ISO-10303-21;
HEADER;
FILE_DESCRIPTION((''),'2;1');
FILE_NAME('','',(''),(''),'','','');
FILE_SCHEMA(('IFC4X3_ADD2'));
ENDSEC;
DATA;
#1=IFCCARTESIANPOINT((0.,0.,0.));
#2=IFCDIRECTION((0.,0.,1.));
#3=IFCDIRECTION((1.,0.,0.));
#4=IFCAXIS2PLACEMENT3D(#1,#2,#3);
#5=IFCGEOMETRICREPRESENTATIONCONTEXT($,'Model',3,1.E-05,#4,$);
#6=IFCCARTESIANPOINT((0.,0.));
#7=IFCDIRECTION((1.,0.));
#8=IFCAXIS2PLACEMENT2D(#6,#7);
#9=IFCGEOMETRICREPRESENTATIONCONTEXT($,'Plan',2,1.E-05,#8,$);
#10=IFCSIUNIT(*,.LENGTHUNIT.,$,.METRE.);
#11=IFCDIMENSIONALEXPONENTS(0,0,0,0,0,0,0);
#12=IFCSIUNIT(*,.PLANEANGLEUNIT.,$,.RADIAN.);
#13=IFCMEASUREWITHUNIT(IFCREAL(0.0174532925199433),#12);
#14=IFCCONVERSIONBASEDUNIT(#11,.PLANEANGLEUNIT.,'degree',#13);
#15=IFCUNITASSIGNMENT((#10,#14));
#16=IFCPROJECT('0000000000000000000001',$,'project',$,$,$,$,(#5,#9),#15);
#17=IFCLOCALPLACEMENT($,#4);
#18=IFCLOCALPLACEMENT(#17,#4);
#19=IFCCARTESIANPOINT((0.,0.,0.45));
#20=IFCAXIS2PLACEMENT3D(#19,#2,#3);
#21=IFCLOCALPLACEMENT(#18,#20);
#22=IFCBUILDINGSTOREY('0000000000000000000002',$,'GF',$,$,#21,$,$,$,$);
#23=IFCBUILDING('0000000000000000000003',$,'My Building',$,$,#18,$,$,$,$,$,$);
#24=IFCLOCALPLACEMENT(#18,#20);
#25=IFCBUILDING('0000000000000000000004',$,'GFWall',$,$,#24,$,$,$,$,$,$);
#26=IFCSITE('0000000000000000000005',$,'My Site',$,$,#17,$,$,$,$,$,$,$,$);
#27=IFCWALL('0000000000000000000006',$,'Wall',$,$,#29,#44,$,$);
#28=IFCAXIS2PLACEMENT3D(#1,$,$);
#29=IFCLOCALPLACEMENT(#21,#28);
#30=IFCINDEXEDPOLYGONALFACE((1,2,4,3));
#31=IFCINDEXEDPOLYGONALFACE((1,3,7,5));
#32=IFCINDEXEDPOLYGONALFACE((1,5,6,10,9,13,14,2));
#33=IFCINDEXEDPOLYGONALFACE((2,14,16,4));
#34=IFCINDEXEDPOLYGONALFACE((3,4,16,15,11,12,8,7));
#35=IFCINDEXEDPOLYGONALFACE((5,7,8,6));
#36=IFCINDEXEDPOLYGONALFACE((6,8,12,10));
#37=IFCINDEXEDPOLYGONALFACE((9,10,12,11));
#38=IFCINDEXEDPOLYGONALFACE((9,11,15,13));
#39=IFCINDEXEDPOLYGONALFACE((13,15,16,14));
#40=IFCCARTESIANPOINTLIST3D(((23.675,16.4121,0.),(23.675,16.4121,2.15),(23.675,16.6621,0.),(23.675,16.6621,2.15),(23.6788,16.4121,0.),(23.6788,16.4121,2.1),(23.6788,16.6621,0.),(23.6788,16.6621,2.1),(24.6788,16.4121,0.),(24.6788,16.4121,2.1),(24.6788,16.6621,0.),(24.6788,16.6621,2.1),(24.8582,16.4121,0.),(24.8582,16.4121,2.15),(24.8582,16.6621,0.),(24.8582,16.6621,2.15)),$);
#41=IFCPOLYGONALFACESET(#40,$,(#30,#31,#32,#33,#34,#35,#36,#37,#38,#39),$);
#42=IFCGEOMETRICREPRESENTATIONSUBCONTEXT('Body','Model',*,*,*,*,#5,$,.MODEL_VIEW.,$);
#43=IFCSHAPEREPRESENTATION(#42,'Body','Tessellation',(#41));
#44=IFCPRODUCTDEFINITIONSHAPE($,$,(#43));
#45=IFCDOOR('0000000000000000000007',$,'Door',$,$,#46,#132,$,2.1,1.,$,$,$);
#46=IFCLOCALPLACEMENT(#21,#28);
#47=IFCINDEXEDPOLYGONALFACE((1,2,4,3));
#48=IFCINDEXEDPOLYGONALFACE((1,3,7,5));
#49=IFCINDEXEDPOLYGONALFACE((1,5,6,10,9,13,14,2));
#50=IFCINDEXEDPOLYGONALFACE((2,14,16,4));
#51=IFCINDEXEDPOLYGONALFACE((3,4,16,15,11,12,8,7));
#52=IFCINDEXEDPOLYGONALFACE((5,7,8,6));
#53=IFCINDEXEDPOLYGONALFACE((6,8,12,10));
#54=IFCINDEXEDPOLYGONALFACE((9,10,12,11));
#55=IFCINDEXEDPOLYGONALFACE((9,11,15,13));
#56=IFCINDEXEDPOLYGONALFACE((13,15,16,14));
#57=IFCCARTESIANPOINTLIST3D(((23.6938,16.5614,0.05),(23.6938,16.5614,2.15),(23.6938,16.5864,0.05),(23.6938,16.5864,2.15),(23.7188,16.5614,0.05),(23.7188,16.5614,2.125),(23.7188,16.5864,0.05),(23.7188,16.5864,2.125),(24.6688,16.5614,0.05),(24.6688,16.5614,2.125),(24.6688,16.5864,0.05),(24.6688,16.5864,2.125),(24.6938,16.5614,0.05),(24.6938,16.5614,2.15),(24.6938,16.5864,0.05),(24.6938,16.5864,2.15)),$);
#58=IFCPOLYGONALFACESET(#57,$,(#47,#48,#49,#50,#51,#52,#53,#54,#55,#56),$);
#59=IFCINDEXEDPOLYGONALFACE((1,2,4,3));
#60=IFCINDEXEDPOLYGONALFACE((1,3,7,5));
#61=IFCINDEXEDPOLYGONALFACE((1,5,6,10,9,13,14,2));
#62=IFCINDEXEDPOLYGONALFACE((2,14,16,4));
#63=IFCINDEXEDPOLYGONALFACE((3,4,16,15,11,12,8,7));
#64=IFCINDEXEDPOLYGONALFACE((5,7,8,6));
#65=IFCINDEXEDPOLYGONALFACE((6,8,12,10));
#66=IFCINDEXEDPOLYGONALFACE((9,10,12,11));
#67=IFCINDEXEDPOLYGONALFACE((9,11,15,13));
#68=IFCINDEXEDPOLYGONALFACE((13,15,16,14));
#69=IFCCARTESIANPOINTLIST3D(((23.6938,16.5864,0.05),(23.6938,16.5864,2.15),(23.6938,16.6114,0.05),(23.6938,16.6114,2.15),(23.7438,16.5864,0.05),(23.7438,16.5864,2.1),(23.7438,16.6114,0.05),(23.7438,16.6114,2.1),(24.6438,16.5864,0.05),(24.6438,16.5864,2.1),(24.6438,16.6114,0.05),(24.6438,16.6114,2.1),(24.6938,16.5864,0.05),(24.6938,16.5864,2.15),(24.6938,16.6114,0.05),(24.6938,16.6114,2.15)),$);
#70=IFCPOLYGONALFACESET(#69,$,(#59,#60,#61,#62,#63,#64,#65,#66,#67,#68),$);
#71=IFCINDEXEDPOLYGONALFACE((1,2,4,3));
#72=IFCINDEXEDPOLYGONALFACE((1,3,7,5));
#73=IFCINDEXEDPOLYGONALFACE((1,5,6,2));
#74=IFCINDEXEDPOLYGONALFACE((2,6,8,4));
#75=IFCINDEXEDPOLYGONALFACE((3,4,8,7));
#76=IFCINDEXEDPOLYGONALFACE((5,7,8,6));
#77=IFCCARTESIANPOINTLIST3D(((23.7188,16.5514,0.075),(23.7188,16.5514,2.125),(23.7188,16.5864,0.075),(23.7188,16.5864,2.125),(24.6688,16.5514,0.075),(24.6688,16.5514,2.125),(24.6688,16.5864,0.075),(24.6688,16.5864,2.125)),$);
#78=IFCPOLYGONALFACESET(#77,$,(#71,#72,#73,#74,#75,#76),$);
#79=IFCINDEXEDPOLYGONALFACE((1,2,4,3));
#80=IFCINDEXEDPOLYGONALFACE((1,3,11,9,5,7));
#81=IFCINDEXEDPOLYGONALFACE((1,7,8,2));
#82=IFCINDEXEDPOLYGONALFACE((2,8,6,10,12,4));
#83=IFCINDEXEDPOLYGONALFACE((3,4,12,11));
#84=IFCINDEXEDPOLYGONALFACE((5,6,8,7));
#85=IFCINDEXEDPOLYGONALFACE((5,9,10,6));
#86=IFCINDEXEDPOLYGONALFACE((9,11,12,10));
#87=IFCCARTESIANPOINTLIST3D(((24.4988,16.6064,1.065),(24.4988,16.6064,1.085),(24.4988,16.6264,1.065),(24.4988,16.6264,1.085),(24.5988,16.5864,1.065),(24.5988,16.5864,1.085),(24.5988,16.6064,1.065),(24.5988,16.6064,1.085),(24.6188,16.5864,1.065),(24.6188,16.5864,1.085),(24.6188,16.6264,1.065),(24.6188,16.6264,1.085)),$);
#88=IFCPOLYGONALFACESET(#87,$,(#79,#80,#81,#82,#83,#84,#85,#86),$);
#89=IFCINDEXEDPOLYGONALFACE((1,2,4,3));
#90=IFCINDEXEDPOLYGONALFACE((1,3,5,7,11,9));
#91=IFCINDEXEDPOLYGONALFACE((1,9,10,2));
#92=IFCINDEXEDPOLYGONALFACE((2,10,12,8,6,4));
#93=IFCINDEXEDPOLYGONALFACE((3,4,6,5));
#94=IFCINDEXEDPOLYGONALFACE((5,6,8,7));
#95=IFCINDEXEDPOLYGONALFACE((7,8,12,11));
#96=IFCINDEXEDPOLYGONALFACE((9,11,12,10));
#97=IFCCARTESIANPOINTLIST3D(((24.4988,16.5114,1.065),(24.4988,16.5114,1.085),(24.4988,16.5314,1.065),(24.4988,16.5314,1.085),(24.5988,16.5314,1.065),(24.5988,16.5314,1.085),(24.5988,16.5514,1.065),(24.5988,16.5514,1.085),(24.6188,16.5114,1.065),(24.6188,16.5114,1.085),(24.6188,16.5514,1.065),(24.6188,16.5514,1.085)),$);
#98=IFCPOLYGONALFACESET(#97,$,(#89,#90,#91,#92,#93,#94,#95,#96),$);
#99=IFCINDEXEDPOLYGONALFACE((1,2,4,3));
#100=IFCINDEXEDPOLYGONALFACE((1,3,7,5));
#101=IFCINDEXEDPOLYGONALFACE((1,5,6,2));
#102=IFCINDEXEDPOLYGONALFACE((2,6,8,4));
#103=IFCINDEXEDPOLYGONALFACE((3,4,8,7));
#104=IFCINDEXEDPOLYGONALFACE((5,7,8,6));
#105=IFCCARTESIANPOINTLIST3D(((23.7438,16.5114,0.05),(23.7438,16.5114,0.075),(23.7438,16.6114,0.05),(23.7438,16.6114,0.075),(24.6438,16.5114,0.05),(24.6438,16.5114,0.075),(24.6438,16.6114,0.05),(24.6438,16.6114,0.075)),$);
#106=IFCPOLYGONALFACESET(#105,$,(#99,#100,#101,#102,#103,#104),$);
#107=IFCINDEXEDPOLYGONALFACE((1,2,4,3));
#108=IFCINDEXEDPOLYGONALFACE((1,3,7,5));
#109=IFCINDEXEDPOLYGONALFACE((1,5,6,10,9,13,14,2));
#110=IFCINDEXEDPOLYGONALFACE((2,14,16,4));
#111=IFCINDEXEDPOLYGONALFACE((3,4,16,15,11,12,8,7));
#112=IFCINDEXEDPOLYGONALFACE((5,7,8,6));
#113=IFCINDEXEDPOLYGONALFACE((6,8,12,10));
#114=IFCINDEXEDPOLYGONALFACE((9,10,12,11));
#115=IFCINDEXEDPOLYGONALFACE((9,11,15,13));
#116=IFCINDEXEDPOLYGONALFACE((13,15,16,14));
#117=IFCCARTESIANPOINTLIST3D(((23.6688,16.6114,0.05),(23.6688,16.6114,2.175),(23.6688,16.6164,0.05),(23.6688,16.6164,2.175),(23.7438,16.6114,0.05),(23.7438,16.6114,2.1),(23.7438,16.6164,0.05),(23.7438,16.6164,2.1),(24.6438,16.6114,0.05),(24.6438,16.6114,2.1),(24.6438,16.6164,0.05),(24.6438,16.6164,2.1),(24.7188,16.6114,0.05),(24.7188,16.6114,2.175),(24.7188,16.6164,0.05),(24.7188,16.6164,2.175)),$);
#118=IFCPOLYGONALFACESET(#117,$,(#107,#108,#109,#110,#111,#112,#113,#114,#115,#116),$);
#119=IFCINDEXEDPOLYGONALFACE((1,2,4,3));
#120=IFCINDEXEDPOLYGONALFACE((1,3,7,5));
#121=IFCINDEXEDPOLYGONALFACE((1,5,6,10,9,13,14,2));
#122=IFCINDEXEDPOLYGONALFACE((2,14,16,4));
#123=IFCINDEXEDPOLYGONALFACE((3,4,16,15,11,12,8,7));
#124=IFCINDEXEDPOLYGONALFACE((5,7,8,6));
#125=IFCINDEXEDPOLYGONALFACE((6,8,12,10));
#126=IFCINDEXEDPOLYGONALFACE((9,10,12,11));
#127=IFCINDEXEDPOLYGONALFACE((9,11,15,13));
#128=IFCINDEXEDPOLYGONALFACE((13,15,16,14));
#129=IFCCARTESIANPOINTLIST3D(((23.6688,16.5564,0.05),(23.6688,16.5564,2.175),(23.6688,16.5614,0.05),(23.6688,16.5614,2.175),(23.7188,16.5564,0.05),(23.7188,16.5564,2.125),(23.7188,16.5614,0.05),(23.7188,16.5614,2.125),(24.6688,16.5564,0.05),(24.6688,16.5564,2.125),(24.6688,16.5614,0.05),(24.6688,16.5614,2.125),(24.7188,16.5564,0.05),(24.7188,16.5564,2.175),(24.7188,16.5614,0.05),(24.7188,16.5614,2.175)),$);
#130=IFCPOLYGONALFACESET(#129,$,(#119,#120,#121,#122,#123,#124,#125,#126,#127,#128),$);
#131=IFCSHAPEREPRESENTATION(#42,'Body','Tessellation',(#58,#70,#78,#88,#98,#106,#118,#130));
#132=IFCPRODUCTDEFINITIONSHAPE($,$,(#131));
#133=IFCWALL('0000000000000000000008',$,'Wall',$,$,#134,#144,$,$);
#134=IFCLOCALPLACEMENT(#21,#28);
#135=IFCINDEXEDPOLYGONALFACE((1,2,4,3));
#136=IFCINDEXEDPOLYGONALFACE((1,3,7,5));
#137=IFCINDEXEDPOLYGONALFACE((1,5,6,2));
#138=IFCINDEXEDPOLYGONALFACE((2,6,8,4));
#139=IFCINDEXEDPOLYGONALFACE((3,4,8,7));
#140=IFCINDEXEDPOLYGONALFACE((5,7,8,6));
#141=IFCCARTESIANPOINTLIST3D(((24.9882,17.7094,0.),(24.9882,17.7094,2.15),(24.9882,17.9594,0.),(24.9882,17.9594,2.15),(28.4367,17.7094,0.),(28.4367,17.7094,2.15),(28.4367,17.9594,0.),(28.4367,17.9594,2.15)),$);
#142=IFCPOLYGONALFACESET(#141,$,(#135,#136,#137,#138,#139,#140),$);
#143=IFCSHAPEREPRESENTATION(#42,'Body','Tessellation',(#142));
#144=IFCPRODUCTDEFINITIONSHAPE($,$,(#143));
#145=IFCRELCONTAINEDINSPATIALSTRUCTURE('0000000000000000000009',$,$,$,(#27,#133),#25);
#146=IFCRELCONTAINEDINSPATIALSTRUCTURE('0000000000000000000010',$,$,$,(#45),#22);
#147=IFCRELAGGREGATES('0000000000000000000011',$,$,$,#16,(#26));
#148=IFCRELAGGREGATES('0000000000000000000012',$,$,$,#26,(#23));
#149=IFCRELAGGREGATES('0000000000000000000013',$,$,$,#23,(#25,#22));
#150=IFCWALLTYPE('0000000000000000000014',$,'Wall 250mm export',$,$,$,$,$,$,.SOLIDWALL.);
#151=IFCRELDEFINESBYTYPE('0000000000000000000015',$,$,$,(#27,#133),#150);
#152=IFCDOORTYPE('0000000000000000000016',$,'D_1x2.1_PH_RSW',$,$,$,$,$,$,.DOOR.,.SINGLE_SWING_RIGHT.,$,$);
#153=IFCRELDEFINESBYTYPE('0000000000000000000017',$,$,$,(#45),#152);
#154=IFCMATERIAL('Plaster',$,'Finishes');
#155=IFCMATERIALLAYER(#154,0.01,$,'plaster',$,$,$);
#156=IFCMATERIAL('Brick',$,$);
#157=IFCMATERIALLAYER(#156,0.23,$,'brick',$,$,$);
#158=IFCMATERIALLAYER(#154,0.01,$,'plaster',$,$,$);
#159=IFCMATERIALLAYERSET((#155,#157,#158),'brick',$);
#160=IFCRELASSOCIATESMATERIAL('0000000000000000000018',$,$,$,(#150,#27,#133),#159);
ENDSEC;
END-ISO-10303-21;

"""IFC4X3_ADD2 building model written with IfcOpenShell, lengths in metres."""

from ifc_helpers import new_model, entity, si_unit, converted_unit, frame, origin_with_axes, origin_2d_with_axis, place, context, subcontext, project, spatial, line, indexed_curve, outline, extrude, shape, source, transform, mapped, material, layer, layer_set, layer_usage, type_object, type_shapes, element, fill, save


model = new_model("IFC4X3_ADD2")

# Units and contexts
model_context = context("Model", 3, precision=1e-05, world=origin_with_axes())
plan_context = context("Plan", 2, precision=1e-05, world=origin_2d_with_axis())
body_context_1 = subcontext(model_context, "Body", "Model", "MODEL_VIEW")
body_context_2 = subcontext(plan_context, "Body", "Plan", "PLAN_VIEW")
ifc_project = project(units=[si_unit("LENGTHUNIT", "METRE"), converted_unit("PLANEANGLEUNIT", "degree", entity("IfcReal", 0.0174532925199433), si_unit("PLANEANGLEUNIT", "RADIAN"), dimensions=[0, 0, 0, 0, 0, 0, 0])], contexts=[model_context, plan_context])

# Site, buildings
site_placement = place(None, origin_with_axes())
site = spatial("IfcSite", under=ifc_project, at=site_placement, Name="My Site")
building_1_placement = place(site_placement, origin_with_axes())
building_1 = spatial("IfcBuilding", under=site, at=building_1_placement, Name="My Building")
building_2_placement = place(building_1_placement, frame((0.0, 0.0, 0.45), z_axis=(0.0, 0.0, 1.0), x_axis=(1.0, 0.0, 0.0)))
building_2 = spatial("IfcBuilding", under=building_1, at=building_2_placement, Name="GFWall")

# Shared definitions
storey_placement = place(building_1_placement, frame((0.0, 0.0, 0.45), z_axis=(0.0, 0.0, 1.0), x_axis=(1.0, 0.0, 0.0)))
storey = spatial("IfcBuildingStorey", under=building_1, at=storey_placement, Name="GF")

# Shared definitions
ifc_material_1 = material(Name="Plaster", Category="Finishes")

# Shared definitions
ifc_layer_1 = layer(ifc_material_1, 0.01, Name="plaster")
ifc_material_2 = material(Name="Brick")
ifc_layer_2 = layer(ifc_material_2, 0.23, Name="brick")
ifc_layer_3 = layer(ifc_material_1, 0.01, Name="plaster")
ifc_layer_set_1 = layer_set([ifc_layer_1, ifc_layer_2, ifc_layer_3], Name="brick")
wall_type_1 = type_object("IfcWallType", Name="Wall 250mm export", PredefinedType="SOLIDWALL", material=ifc_layer_set_1)

# Wall, opening, door
ifc_layer_usage_1 = layer_usage(ifc_layer_set_1, "AXIS2", "POSITIVE", 0.0)
wall_1_placement = place(building_2_placement, frame((23.675, 16.4121, 0.0), z_axis=(0.0, 0.0, 1.0), x_axis=(1.0, 0.0, 0.0)))
wall_1 = element("IfcWall", 1, at=wall_1_placement, inside=building_2, type_object=wall_type_1, material=ifc_layer_usage_1, Name="Wall", context=body_context_1, shape_type="SweptSolid", body=[
    extrude(outline(indexed_curve([(0.0, 0.0), (0.0, 0.25), (1.1832, 0.25), (1.1832, 0.0)], segments=[line(1, 2, 3, 4, 1)])), origin_with_axes(), (0.0, 0.0, 1.0), 2.15),
])
shared_shape_1 = source(origin_with_axes(), body_context_1, "Body", "SweptSolid", [
    extrude(outline(indexed_curve([(0.0, 0.0), (1.0, 0.0), (1.0, 2.1), (0.0, 2.1)], segments=[line(1, 2, 3, 4, 1)])), frame((0.0, -0.6, 0.0), z_axis=(0.0, -1.0, 0.0), x_axis=(1.0, 0.0, 0.0)), (0.0, 0.0, -1.0), 1.2),
])
opening_1_placement = place(wall_1_placement, frame((1.0037, 0.095, 0.0), z_axis=(0.0, 0.0, 1.0), x_axis=(-1.0, 0.0, 0.0)))
opening_1 = element("IfcOpeningElement", 2, at=opening_1_placement, cuts=wall_1, PredefinedType="OPENING", context=body_context_1, shape_type="MappedRepresentation", body=[
    mapped(shared_shape_1, transform((0.0, 0.0, 0.0), x_axis=(1.0, 0.0, 0.0), y_axis=(0.0, 1.0, 0.0), z_axis=(0.0, 0.0, 1.0), scale=1.0)),
])
door_type_1 = type_object("IfcDoorType", Name="D_1x2.1_PH_RSW", OperationType="SINGLE_SWING_RIGHT", PredefinedType="DOOR")
shared_shape_2 = source(origin_with_axes(), body_context_1, "Body", "SweptSolid", [
    extrude(outline(indexed_curve([(0.0, 0.0), (0.0, 2.1), (1.0, 2.1), (1.0, 0.0), (0.975, 0.0), (0.975, 2.075), (0.025, 2.075), (0.025, 0.0)], segments=[line(1, 2, 3, 4, 5, 6, 7, 8, 1)])), frame((0.0, 0.025, 0.0), z_axis=(0.0, -1.0, 0.0), x_axis=(1.0, 0.0, 0.0)), (0.0, 0.0, -1.0), 0.025),
    extrude(outline(indexed_curve([(0.0, 0.0), (0.0, 2.1), (1.0, 2.1), (1.0, 0.0), (0.95, 0.0), (0.95, 2.05), (0.05, 2.05), (0.05, 0.0)], segments=[line(1, 2, 3, 4, 5, 6, 7, 8, 1)])), frame((0.0, 0.0, 0.0), z_axis=(0.0, -1.0, 0.0), x_axis=(1.0, 0.0, 0.0)), (0.0, 0.0, -1.0), 0.025),
    extrude(outline(indexed_curve([(0.0, 0.0), (0.95, 0.0), (0.95, 0.035), (0.0, 0.035)], segments=[line(1, 2, 3, 4, 1)])), frame((0.025, 0.025, 0.025), z_axis=(0.0, 0.0, 1.0), x_axis=(1.0, 0.0, 0.0)), (0.0, 0.0, 1.0), 2.05),
    extrude(outline(indexed_curve([(0.0, 0.0), (0.0, -0.04), (0.12, -0.04), (0.12, -0.02), (0.02, -0.02), (0.02, 0.0)], segments=[line(1, 2, 3, 4, 5, 6, 1)])), frame((0.075, 0.025, 1.015), z_axis=(0.0, 0.0, 1.0), x_axis=(1.0, 0.0, 0.0)), (0.0, 0.0, 1.0), 0.02),
    extrude(outline(indexed_curve([(0.0, 0.0), (0.0, 0.04), (0.12, 0.04), (0.12, 0.02), (0.02, 0.02), (0.02, 0.0)], segments=[line(1, 2, 3, 4, 5, 6, 1)])), frame((0.075, 0.06, 1.015), z_axis=(0.0, 0.0, 1.0), x_axis=(1.0, 0.0, 0.0)), (0.0, 0.0, 1.0), 0.02),
    extrude(outline(indexed_curve([(0.0, 0.0), (0.9, 0.0), (0.9, 0.1), (0.0, 0.1)], segments=[line(1, 2, 3, 4, 1)])), frame((0.05, 0.0, 0.0), z_axis=(0.0, 0.0, 1.0), x_axis=(1.0, 0.0, 0.0)), (0.0, 0.0, 1.0), 0.025),
    extrude(outline(indexed_curve([(0.0, 0.0), (0.0, 2.125), (1.05, 2.125), (1.05, 0.0), (0.975, 0.0), (0.975, 2.05), (0.075, 2.05), (0.075, 0.0)], segments=[line(1, 2, 3, 4, 5, 6, 7, 8, 1)])), frame((-0.025, -0.005, 0.0), z_axis=(0.0, -1.0, 0.0), x_axis=(1.0, 0.0, 0.0)), (0.0, 0.0, -1.0), 0.005),
    extrude(outline(indexed_curve([(0.0, 0.0), (0.0, 2.125), (1.05, 2.125), (1.05, 0.0), (1.0, 0.0), (1.0, 2.075), (0.05, 2.075), (0.05, 0.0)], segments=[line(1, 2, 3, 4, 5, 6, 7, 8, 1)])), frame((-0.025, 0.05, 0.0), z_axis=(0.0, -1.0, 0.0), x_axis=(1.0, 0.0, 0.0)), (0.0, 0.0, -1.0), 0.005),
])
shared_shape_3 = source(origin_with_axes(), body_context_2, "Body", "Curve2D", [
    entity("IfcIndexedPolyCurve", entity("IfcCartesianPointList2D", [[0.0, 0.0], [0.0, 0.05], [0.025, 0.05], [0.025, 0.025], [0.05, 0.025], [0.05, 0.0]]), [entity("IfcLineIndex", [1, 2, 3, 4, 5, 6, 1])]),
    entity("IfcIndexedPolyCurve", entity("IfcCartesianPointList2D", [[1.0, 0.0], [1.0, 0.05], [0.975, 0.05], [0.975, 0.025], [0.95, 0.025], [0.95, 0.0]]), [entity("IfcLineIndex", [1, 2, 3, 4, 5, 6, 1])]),
    entity("IfcTrimmedCurve", entity("IfcEllipse", entity("IfcAxis2Placement2D", entity("IfcCartesianPoint", [0.94, 0.05]), entity("IfcDirection", [1.0, 0.0])), 0.915, 0.95), [entity("IfcCartesianPoint", [0.94, 1.0])], [entity("IfcCartesianPoint", [0.025, 0.05])], True, "CARTESIAN"),
    entity("IfcIndexedPolyCurve", entity("IfcCartesianPointList2D", [[0.975, 0.05], [0.94, 0.05], [0.94, 1.0], [0.975, 1.0]]), [entity("IfcLineIndex", [1, 2, 3, 4, 1])]),
])
type_shapes(door_type_1, [shared_shape_2, shared_shape_3])
door_1_placement = place(opening_1_placement, frame((-0.015, -0.1044, 0.05), z_axis=(0.0, 0.0, 1.0), x_axis=(1.0, 0.0, 0.0)))
door_1 = element("IfcDoor", 3, at=door_1_placement, inside=storey, type_object=door_type_1, Name="Door", OverallHeight=2.1, OverallWidth=1.0, shapes=[
    shape(body_context_1, "Body", "MappedRepresentation", [mapped(shared_shape_2, transform((0.0, 0.0, 0.0), x_axis=(1.0, 0.0, 0.0), y_axis=(0.0, 1.0, 0.0), z_axis=(0.0, 0.0, 1.0), scale=1.0))]),
    shape(body_context_2, "Body", "MappedRepresentation", [mapped(shared_shape_3, transform((0.0, 0.0, 0.0), x_axis=(1.0, 0.0, 0.0), y_axis=(0.0, 1.0, 0.0), z_axis=(0.0, 0.0, 1.0), scale=1.0))]),
])
fill(opening_1, door_1)

# Wall
ifc_layer_usage_2 = layer_usage(ifc_layer_set_1, "AXIS2", "POSITIVE", 0.0)
wall_2_placement = place(building_2_placement, frame((24.9882, 17.7094, 0.0), z_axis=(0.0, 0.0, 1.0), x_axis=(1.0, 0.0, 0.0)))
element("IfcWall", 4, at=wall_2_placement, inside=building_2, type_object=wall_type_1, material=ifc_layer_usage_2, Name="Wall", context=body_context_1, shape_type="SweptSolid", body=[
    extrude(outline(indexed_curve([(0.0, 0.0), (0.0, 0.25), (3.4485, 0.25), (3.4485, 0.0)], segments=[line(1, 2, 3, 4, 1)])), origin_with_axes(), (0.0, 0.0, 1.0), 2.15),
])

save(model, "model.ifc")
